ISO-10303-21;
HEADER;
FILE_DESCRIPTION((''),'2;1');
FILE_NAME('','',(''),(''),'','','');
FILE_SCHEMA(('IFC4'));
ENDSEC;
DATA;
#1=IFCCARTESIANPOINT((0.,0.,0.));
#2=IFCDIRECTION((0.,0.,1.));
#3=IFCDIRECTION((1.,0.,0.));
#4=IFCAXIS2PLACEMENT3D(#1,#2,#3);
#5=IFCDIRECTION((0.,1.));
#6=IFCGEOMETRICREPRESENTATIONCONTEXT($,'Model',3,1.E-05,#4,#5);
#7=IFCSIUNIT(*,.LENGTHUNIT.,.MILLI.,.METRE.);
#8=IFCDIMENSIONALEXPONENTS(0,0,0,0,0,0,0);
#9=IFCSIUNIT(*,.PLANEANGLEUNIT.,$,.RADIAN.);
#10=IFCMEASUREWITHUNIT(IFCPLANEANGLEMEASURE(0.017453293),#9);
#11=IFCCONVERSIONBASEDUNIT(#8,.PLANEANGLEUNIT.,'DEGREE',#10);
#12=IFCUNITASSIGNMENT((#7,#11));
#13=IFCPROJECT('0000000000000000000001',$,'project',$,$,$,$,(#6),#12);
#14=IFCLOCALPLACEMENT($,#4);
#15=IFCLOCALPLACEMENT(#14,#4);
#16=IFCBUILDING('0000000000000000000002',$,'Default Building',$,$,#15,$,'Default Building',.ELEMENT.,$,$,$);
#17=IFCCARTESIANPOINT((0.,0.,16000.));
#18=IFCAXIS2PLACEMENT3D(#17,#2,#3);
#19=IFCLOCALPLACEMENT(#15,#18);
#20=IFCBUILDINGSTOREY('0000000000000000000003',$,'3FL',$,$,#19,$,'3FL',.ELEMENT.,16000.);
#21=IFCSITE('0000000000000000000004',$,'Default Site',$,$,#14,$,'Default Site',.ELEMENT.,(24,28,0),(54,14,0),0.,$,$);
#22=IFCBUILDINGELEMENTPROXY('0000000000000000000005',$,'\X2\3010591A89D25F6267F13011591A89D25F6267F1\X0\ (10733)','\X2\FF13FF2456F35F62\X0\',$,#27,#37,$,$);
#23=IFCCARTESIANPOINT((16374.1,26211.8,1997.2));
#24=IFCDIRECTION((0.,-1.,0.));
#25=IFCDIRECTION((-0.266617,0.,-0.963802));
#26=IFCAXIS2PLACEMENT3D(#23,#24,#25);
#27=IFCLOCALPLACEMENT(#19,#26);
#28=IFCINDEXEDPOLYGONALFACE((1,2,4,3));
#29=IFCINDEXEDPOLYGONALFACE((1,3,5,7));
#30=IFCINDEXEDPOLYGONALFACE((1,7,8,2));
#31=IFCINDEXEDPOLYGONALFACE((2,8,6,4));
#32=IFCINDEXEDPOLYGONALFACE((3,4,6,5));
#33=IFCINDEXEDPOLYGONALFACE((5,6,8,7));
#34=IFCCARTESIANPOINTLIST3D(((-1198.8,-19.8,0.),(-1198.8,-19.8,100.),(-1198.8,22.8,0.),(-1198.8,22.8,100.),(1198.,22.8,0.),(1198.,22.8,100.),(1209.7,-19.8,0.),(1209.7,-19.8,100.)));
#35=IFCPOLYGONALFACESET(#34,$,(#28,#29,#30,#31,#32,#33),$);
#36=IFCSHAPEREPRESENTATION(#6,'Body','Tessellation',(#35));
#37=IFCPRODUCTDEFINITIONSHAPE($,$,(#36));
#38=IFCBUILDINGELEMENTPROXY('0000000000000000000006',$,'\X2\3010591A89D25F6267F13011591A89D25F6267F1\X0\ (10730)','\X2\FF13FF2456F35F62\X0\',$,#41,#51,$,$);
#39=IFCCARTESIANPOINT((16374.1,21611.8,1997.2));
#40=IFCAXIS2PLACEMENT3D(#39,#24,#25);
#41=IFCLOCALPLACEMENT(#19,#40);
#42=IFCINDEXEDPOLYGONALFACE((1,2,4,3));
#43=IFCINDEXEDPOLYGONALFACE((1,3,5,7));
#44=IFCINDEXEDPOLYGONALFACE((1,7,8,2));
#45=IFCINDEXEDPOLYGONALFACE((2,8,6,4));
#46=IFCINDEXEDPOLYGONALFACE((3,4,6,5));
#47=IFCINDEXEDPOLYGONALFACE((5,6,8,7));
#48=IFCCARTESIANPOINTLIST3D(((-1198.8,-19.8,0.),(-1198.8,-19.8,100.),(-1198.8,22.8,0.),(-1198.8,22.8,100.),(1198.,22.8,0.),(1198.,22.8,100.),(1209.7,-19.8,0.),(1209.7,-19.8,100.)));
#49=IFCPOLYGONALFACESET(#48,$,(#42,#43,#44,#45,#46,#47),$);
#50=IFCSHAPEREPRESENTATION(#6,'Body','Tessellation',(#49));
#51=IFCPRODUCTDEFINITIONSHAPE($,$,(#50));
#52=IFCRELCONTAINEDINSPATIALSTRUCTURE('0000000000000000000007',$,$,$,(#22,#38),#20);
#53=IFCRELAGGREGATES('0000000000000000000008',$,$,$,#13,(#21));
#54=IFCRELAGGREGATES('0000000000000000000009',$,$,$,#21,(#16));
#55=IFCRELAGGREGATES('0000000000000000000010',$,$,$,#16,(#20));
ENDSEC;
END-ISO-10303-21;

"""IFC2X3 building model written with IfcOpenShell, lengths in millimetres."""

from ifc_helpers import new_model, entity, si_unit, converted_unit, direction, frame, origin_with_axes, place, context, project, spatial, polyline, outline, extrude, source, transform, mapped, element, save


model = new_model("IFC2X3")

# Units and contexts
model_context = context("Model", 3, precision=1e-05, world=origin_with_axes(), true_north=direction((0.0, 1.0)))
ifc_project = project(units=[si_unit("LENGTHUNIT", "METRE", prefix="MILLI"), converted_unit("PLANEANGLEUNIT", "DEGREE", entity("IfcPlaneAngleMeasure", 0.017453293), si_unit("PLANEANGLEUNIT", "RADIAN"), dimensions=[0, 0, 0, 0, 0, 0, 0])], contexts=[model_context])

# Site, building, storey
site_placement = place(None, origin_with_axes())
site = spatial("IfcSite", under=ifc_project, at=site_placement, Name="Default Site", LongName="Default Site", CompositionType="ELEMENT", RefLatitude=(24, 28, 0), RefLongitude=(54, 14, 0), RefElevation=0.0)
building_placement = place(site_placement, origin_with_axes())
building = spatial("IfcBuilding", under=site, at=building_placement, Name="Default Building", LongName="Default Building", CompositionType="ELEMENT")
storey_placement = place(building_placement, frame((0.0, 0.0, 16000.0), z_axis=(0.0, 0.0, 1.0), x_axis=(1.0, 0.0, 0.0)))
storey = spatial("IfcBuildingStorey", under=building, at=storey_placement, Name="3FL", LongName="3FL", CompositionType="ELEMENT", Elevation=16000.0)

# Building element proxies
shared_shape_1 = source(origin_with_axes(), model_context, "Body", "SweptSolid", [
    extrude(outline(polyline([(-1198.8, -19.8), (1209.7, -19.8), (1198.0, 22.8), (-1198.8, 22.8), (-1198.8, -19.8)])), frame((0.0, 0.0, 0.0), z_axis=(0.0, 0.0, 1.0), x_axis=(1.0, 0.0, 0.0)), (0.0, 0.0, 1.0), 100.0),
])
proxy_1_placement = place(storey_placement, frame((16374.1, 26211.8, 1997.2), z_axis=(0.0, -1.0, 0.0), x_axis=(-0.266617, 0.0, -0.963802)))
element("IfcBuildingElementProxy", 1, at=proxy_1_placement, inside=storey, Name="【多角形柱】多角形柱 (10733)", Description="３Ｄ図形", context=model_context, shape_type="MappedRepresentation", body=[
    mapped(shared_shape_1, transform((0.0, 0.0, 0.0))),
])
shared_shape_2 = source(origin_with_axes(), model_context, "Body", "SweptSolid", [
    extrude(outline(polyline([(-1198.8, -19.8), (1209.7, -19.8), (1198.0, 22.8), (-1198.8, 22.8), (-1198.8, -19.8)])), frame((0.0, 0.0, 0.0), z_axis=(0.0, 0.0, 1.0), x_axis=(1.0, 0.0, 0.0)), (0.0, 0.0, 1.0), 100.0),
])
proxy_2_placement = place(storey_placement, frame((16374.1, 21611.8, 1997.2), z_axis=(0.0, -1.0, 0.0), x_axis=(-0.266617, 0.0, -0.963802)))
element("IfcBuildingElementProxy", 2, at=proxy_2_placement, inside=storey, Name="【多角形柱】多角形柱 (10730)", Description="３Ｄ図形", context=model_context, shape_type="MappedRepresentation", body=[
    mapped(shared_shape_2, transform((0.0, 0.0, 0.0))),
])

save(model, "model.ifc")
